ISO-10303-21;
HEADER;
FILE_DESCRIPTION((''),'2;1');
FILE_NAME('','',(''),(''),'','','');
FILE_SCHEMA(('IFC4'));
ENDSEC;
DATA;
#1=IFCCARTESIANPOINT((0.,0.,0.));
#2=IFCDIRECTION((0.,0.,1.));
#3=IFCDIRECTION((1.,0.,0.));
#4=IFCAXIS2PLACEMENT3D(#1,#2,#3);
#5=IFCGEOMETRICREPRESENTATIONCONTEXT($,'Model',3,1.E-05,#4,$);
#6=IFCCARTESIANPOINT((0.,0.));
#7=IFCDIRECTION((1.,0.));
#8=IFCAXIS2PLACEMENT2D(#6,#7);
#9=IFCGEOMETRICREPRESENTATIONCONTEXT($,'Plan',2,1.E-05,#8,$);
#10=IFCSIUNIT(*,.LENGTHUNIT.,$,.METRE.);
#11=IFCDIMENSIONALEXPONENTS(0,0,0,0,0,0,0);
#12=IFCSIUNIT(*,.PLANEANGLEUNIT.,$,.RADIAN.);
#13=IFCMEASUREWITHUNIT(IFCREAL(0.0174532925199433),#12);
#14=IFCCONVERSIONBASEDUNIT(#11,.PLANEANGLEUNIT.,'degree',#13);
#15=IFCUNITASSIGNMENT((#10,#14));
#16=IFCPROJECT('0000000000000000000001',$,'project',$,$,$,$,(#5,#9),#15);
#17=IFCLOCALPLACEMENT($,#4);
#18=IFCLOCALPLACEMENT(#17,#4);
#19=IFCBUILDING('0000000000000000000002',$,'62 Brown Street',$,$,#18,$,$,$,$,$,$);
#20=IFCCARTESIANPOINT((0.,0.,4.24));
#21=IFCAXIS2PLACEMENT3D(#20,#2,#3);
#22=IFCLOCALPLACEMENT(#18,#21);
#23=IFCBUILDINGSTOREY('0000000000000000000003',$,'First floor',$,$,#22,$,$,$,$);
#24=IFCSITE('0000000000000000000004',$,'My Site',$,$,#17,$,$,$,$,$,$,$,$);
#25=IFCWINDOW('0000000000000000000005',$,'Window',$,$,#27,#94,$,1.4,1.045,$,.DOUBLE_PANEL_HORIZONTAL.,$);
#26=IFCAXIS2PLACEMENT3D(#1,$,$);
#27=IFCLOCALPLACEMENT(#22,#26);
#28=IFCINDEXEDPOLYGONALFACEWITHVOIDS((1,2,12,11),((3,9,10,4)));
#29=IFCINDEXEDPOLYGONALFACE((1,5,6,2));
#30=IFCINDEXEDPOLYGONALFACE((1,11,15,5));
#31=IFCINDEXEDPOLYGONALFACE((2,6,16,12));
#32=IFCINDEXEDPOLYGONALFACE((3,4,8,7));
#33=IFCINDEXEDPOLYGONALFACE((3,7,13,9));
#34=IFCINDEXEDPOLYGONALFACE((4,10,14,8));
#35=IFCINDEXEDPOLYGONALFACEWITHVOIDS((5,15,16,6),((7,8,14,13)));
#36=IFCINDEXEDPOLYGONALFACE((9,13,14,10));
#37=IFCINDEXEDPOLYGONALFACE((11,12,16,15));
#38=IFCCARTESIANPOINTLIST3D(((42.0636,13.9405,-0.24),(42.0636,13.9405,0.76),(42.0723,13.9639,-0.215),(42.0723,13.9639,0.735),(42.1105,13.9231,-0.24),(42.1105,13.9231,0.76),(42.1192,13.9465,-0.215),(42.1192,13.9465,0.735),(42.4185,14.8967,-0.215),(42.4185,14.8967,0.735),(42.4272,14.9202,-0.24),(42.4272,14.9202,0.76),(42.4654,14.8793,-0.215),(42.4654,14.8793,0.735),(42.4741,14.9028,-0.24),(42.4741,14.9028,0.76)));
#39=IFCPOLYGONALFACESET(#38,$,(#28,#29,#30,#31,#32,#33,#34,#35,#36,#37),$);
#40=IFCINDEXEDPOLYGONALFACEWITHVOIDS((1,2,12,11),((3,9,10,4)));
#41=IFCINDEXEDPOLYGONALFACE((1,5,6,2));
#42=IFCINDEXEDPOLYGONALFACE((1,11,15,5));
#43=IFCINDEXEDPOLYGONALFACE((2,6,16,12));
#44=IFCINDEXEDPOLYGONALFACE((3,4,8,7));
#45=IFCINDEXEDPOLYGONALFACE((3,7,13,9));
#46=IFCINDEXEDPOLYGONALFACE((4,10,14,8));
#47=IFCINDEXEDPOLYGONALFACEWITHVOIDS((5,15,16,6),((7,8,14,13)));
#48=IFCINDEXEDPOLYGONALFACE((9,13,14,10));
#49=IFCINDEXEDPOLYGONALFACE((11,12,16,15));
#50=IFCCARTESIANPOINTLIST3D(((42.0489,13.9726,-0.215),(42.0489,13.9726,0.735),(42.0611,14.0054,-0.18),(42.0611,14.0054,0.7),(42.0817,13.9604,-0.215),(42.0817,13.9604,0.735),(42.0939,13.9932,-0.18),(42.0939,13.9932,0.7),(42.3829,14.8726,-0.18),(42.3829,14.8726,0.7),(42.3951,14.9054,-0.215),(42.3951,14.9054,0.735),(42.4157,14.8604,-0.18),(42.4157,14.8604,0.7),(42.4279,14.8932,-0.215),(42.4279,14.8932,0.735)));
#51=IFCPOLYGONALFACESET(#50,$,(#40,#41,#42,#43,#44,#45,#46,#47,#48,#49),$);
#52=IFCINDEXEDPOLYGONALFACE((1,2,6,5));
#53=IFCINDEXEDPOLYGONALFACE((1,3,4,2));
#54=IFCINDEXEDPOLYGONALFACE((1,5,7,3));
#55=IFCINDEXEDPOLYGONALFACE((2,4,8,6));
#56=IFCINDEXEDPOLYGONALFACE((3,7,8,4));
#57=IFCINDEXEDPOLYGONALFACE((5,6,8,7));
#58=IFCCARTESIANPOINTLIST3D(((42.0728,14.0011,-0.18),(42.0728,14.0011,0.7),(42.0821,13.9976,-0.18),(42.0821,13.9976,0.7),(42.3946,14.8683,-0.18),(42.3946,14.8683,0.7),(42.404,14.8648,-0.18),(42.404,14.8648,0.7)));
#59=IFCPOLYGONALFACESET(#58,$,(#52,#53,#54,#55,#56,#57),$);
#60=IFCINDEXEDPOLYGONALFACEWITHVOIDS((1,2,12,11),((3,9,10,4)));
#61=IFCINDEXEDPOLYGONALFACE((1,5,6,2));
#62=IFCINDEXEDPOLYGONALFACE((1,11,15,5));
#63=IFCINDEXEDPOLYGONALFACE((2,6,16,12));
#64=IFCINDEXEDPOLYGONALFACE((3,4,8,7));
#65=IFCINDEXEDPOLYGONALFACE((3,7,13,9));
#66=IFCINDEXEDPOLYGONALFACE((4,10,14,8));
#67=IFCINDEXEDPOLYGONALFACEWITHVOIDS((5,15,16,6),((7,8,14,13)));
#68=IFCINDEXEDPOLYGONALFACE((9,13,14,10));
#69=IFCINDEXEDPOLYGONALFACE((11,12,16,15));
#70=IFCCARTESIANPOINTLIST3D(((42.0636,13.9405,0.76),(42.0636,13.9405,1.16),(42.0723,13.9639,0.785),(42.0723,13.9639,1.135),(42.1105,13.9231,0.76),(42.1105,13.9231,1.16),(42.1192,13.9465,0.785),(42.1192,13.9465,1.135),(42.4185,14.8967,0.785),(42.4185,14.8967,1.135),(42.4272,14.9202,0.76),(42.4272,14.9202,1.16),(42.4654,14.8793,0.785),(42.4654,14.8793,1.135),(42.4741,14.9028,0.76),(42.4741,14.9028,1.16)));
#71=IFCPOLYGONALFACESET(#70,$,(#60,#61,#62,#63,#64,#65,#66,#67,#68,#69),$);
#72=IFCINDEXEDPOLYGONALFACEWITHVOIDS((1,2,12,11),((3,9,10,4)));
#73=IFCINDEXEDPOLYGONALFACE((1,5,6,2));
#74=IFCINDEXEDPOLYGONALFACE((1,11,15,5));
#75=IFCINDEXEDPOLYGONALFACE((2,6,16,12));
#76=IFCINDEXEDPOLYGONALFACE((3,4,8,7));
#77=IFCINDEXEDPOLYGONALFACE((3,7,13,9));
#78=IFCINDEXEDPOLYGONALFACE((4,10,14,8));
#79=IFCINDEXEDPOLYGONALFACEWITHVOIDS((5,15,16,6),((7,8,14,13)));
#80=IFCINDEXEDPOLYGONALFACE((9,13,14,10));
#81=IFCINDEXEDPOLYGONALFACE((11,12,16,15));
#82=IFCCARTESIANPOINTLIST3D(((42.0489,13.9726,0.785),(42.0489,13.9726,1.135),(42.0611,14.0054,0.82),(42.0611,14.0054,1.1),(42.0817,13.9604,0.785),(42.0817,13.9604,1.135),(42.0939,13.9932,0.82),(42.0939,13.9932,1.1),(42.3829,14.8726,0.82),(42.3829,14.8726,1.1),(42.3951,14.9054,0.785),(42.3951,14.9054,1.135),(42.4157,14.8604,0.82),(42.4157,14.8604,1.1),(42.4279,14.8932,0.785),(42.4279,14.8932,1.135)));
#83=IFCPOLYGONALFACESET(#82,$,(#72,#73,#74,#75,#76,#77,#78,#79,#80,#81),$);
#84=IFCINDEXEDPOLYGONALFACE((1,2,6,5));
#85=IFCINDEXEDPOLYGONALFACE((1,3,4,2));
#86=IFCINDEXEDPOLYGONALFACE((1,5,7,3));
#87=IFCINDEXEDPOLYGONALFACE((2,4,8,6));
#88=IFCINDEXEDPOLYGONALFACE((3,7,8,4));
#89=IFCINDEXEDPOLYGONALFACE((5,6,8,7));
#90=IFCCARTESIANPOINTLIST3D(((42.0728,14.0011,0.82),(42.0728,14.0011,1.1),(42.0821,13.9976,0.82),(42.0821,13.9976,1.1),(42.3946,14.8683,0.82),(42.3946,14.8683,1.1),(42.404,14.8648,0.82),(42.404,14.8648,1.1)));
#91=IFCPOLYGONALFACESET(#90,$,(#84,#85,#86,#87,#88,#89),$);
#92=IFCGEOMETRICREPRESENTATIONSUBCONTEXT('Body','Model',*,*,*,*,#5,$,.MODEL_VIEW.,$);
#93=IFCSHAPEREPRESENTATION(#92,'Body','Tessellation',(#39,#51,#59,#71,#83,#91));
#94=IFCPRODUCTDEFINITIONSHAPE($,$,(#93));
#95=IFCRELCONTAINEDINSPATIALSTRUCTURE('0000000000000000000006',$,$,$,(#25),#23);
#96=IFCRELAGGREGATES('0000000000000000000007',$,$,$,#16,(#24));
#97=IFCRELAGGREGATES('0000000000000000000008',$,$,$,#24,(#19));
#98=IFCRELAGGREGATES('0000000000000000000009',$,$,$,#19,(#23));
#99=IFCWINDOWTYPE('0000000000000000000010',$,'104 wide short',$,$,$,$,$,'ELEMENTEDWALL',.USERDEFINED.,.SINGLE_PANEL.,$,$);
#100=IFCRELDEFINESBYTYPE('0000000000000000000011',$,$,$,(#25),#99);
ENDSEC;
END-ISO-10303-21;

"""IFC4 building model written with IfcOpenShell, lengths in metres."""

from ifc_helpers import new_model, entity, si_unit, converted_unit, frame, origin_with_axes, origin_2d_with_axis, place, context, subcontext, project, spatial, line, indexed_curve, outline, extrude, shape, source, transform, mapped, type_object, type_shapes, element, save


model = new_model("IFC4")

# Units and contexts
model_context = context("Model", 3, precision=1e-05, world=origin_with_axes())
plan_context = context("Plan", 2, precision=1e-05, world=origin_2d_with_axis())
body_context_1 = subcontext(model_context, "Body", "Model", "MODEL_VIEW")
body_context_2 = subcontext(plan_context, "Body", "Plan", "PLAN_VIEW")
ifc_project = project(units=[si_unit("LENGTHUNIT", "METRE"), converted_unit("PLANEANGLEUNIT", "degree", entity("IfcReal", 0.0174532925199433), si_unit("PLANEANGLEUNIT", "RADIAN"), dimensions=[0, 0, 0, 0, 0, 0, 0])], contexts=[model_context, plan_context])

# Site, building, storey
site_placement = place(None, origin_with_axes())
site = spatial("IfcSite", under=ifc_project, at=site_placement, Name="My Site")
building_placement = place(site_placement, origin_with_axes())
building = spatial("IfcBuilding", under=site, at=building_placement, Name="62 Brown Street")
storey_placement = place(building_placement, frame((0.0, 0.0, 4.24), z_axis=(0.0, 0.0, 1.0), x_axis=(1.0, 0.0, 0.0)))
storey = spatial("IfcBuildingStorey", under=building, at=storey_placement, Name="First floor")

# Shared definitions
window_type = type_object("IfcWindowType", Name="104 wide short", ElementType="ELEMENTEDWALL", PartitioningType="SINGLE_PANEL", PredefinedType="USERDEFINED")
shared_shape_1 = source(origin_with_axes(), body_context_1, "Body", "SweptSolid", [
    extrude(outline(indexed_curve([(0.0, 0.0), (1.045, 0.0), (1.045, 1.0), (0.0, 1.0)], segments=[line(1, 2, 3, 4, 1)]), holes=[indexed_curve([(0.025, 0.025), (1.02, 0.025), (1.02, 0.975), (0.025, 0.975)], segments=[line(1, 2, 3, 4, 1)])]), frame((0.0, 0.15, 0.0), z_axis=(0.0, -1.0, 0.0), x_axis=(1.0, 0.0, 0.0)), (0.0, 0.0, -1.0), 0.05),
    extrude(outline(indexed_curve([(0.0, 0.0), (0.995, 0.0), (0.995, 0.95), (0.0, 0.95)], segments=[line(1, 2, 3, 4, 1)]), holes=[indexed_curve([(0.035, 0.035), (0.96, 0.035), (0.96, 0.915), (0.035, 0.915)], segments=[line(1, 2, 3, 4, 1)])]), frame((0.025, 0.19, 0.025), z_axis=(0.0, -1.0, 0.0), x_axis=(1.0, 0.0, 0.0)), (0.0, 0.0, -1.0), 0.035),
    extrude(outline(indexed_curve([(0.035, 0.035), (0.96, 0.035), (0.96, 0.915), (0.035, 0.915)], segments=[line(1, 2, 3, 4, 1)])), frame((0.025, 0.2025, 0.025), z_axis=(0.0, -1.0, 0.0), x_axis=(1.0, 0.0, 0.0)), (0.0, 0.0, -1.0), 0.01),
    extrude(outline(indexed_curve([(0.0, 0.0), (1.045, 0.0), (1.045, 0.4), (0.0, 0.4)], segments=[line(1, 2, 3, 4, 1)]), holes=[indexed_curve([(0.025, 0.025), (1.02, 0.025), (1.02, 0.375), (0.025, 0.375)], segments=[line(1, 2, 3, 4, 1)])]), frame((0.0, 0.15, 1.0), z_axis=(0.0, -1.0, 0.0), x_axis=(1.0, 0.0, 0.0)), (0.0, 0.0, -1.0), 0.05),
    extrude(outline(indexed_curve([(0.0, 0.0), (0.995, 0.0), (0.995, 0.35), (0.0, 0.35)], segments=[line(1, 2, 3, 4, 1)]), holes=[indexed_curve([(0.035, 0.035), (0.96, 0.035), (0.96, 0.315), (0.035, 0.315)], segments=[line(1, 2, 3, 4, 1)])]), frame((0.025, 0.19, 1.025), z_axis=(0.0, -1.0, 0.0), x_axis=(1.0, 0.0, 0.0)), (0.0, 0.0, -1.0), 0.035),
    extrude(outline(indexed_curve([(0.035, 0.035), (0.96, 0.035), (0.96, 0.315), (0.035, 0.315)], segments=[line(1, 2, 3, 4, 1)])), frame((0.025, 0.2025, 1.025), z_axis=(0.0, -1.0, 0.0), x_axis=(1.0, 0.0, 0.0)), (0.0, 0.0, -1.0), 0.01),
])
shared_shape_2 = source(origin_with_axes(), body_context_2, "Body", "Curve2D", [
    entity("IfcIndexedPolyCurve", entity("IfcCartesianPointList2D", [[0.025, 0.15], [1.02, 0.15]])),
    entity("IfcIndexedPolyCurve", entity("IfcCartesianPointList2D", [[0.0, 0.2], [0.025, 0.2], [0.025, 0.15], [0.0, 0.15]]), [entity("IfcLineIndex", [1, 2, 3, 4, 1])]),
    entity("IfcIndexedPolyCurve", entity("IfcCartesianPointList2D", [[1.045, 0.2], [1.02, 0.2], [1.02, 0.15], [1.045, 0.15]]), [entity("IfcLineIndex", [1, 2, 3, 4, 1])]),
    entity("IfcIndexedPolyCurve", entity("IfcCartesianPointList2D", [[0.025, 0.19], [0.06, 0.19], [0.06, 0.225], [0.025, 0.225]]), [entity("IfcLineIndex", [1, 2, 3, 4, 1])]),
    entity("IfcIndexedPolyCurve", entity("IfcCartesianPointList2D", [[1.02, 0.19], [0.985, 0.19], [0.985, 0.225], [1.02, 0.225]]), [entity("IfcLineIndex", [1, 2, 3, 4, 1])]),
    entity("IfcIndexedPolyCurve", entity("IfcCartesianPointList2D", [[0.06, 0.19], [0.985, 0.19]])),
    entity("IfcIndexedPolyCurve", entity("IfcCartesianPointList2D", [[0.06, 0.225], [0.985, 0.225]])),
    entity("IfcIndexedPolyCurve", entity("IfcCartesianPointList2D", [[0.06, 0.2075], [0.985, 0.2075]])),
])
type_shapes(window_type, [shared_shape_1, shared_shape_2])

# Window
window_1_placement = place(storey_placement, frame((42.2511, 13.8709, -0.24), z_axis=(0.0, 0.0, 1.0), x_axis=(0.347944, 0.937515, 0.0)))
element("IfcWindow", 1, at=window_1_placement, inside=storey, type_object=window_type, Name="Window", OverallHeight=1.4, OverallWidth=1.045, PartitioningType="DOUBLE_PANEL_HORIZONTAL", shapes=[
    shape(body_context_1, "Body", "MappedRepresentation", [mapped(shared_shape_1, transform((0.0, 0.0, 0.0), x_axis=(1.0, 0.0, 0.0), y_axis=(0.0, 1.0, 0.0), z_axis=(0.0, 0.0, 1.0), scale=1.0))]),
    shape(body_context_2, "Body", "MappedRepresentation", [mapped(shared_shape_2, transform((0.0, 0.0, 0.0), x_axis=(1.0, 0.0, 0.0), y_axis=(0.0, 1.0, 0.0), z_axis=(0.0, 0.0, 1.0), scale=1.0))]),
])

save(model, "model.ifc")
